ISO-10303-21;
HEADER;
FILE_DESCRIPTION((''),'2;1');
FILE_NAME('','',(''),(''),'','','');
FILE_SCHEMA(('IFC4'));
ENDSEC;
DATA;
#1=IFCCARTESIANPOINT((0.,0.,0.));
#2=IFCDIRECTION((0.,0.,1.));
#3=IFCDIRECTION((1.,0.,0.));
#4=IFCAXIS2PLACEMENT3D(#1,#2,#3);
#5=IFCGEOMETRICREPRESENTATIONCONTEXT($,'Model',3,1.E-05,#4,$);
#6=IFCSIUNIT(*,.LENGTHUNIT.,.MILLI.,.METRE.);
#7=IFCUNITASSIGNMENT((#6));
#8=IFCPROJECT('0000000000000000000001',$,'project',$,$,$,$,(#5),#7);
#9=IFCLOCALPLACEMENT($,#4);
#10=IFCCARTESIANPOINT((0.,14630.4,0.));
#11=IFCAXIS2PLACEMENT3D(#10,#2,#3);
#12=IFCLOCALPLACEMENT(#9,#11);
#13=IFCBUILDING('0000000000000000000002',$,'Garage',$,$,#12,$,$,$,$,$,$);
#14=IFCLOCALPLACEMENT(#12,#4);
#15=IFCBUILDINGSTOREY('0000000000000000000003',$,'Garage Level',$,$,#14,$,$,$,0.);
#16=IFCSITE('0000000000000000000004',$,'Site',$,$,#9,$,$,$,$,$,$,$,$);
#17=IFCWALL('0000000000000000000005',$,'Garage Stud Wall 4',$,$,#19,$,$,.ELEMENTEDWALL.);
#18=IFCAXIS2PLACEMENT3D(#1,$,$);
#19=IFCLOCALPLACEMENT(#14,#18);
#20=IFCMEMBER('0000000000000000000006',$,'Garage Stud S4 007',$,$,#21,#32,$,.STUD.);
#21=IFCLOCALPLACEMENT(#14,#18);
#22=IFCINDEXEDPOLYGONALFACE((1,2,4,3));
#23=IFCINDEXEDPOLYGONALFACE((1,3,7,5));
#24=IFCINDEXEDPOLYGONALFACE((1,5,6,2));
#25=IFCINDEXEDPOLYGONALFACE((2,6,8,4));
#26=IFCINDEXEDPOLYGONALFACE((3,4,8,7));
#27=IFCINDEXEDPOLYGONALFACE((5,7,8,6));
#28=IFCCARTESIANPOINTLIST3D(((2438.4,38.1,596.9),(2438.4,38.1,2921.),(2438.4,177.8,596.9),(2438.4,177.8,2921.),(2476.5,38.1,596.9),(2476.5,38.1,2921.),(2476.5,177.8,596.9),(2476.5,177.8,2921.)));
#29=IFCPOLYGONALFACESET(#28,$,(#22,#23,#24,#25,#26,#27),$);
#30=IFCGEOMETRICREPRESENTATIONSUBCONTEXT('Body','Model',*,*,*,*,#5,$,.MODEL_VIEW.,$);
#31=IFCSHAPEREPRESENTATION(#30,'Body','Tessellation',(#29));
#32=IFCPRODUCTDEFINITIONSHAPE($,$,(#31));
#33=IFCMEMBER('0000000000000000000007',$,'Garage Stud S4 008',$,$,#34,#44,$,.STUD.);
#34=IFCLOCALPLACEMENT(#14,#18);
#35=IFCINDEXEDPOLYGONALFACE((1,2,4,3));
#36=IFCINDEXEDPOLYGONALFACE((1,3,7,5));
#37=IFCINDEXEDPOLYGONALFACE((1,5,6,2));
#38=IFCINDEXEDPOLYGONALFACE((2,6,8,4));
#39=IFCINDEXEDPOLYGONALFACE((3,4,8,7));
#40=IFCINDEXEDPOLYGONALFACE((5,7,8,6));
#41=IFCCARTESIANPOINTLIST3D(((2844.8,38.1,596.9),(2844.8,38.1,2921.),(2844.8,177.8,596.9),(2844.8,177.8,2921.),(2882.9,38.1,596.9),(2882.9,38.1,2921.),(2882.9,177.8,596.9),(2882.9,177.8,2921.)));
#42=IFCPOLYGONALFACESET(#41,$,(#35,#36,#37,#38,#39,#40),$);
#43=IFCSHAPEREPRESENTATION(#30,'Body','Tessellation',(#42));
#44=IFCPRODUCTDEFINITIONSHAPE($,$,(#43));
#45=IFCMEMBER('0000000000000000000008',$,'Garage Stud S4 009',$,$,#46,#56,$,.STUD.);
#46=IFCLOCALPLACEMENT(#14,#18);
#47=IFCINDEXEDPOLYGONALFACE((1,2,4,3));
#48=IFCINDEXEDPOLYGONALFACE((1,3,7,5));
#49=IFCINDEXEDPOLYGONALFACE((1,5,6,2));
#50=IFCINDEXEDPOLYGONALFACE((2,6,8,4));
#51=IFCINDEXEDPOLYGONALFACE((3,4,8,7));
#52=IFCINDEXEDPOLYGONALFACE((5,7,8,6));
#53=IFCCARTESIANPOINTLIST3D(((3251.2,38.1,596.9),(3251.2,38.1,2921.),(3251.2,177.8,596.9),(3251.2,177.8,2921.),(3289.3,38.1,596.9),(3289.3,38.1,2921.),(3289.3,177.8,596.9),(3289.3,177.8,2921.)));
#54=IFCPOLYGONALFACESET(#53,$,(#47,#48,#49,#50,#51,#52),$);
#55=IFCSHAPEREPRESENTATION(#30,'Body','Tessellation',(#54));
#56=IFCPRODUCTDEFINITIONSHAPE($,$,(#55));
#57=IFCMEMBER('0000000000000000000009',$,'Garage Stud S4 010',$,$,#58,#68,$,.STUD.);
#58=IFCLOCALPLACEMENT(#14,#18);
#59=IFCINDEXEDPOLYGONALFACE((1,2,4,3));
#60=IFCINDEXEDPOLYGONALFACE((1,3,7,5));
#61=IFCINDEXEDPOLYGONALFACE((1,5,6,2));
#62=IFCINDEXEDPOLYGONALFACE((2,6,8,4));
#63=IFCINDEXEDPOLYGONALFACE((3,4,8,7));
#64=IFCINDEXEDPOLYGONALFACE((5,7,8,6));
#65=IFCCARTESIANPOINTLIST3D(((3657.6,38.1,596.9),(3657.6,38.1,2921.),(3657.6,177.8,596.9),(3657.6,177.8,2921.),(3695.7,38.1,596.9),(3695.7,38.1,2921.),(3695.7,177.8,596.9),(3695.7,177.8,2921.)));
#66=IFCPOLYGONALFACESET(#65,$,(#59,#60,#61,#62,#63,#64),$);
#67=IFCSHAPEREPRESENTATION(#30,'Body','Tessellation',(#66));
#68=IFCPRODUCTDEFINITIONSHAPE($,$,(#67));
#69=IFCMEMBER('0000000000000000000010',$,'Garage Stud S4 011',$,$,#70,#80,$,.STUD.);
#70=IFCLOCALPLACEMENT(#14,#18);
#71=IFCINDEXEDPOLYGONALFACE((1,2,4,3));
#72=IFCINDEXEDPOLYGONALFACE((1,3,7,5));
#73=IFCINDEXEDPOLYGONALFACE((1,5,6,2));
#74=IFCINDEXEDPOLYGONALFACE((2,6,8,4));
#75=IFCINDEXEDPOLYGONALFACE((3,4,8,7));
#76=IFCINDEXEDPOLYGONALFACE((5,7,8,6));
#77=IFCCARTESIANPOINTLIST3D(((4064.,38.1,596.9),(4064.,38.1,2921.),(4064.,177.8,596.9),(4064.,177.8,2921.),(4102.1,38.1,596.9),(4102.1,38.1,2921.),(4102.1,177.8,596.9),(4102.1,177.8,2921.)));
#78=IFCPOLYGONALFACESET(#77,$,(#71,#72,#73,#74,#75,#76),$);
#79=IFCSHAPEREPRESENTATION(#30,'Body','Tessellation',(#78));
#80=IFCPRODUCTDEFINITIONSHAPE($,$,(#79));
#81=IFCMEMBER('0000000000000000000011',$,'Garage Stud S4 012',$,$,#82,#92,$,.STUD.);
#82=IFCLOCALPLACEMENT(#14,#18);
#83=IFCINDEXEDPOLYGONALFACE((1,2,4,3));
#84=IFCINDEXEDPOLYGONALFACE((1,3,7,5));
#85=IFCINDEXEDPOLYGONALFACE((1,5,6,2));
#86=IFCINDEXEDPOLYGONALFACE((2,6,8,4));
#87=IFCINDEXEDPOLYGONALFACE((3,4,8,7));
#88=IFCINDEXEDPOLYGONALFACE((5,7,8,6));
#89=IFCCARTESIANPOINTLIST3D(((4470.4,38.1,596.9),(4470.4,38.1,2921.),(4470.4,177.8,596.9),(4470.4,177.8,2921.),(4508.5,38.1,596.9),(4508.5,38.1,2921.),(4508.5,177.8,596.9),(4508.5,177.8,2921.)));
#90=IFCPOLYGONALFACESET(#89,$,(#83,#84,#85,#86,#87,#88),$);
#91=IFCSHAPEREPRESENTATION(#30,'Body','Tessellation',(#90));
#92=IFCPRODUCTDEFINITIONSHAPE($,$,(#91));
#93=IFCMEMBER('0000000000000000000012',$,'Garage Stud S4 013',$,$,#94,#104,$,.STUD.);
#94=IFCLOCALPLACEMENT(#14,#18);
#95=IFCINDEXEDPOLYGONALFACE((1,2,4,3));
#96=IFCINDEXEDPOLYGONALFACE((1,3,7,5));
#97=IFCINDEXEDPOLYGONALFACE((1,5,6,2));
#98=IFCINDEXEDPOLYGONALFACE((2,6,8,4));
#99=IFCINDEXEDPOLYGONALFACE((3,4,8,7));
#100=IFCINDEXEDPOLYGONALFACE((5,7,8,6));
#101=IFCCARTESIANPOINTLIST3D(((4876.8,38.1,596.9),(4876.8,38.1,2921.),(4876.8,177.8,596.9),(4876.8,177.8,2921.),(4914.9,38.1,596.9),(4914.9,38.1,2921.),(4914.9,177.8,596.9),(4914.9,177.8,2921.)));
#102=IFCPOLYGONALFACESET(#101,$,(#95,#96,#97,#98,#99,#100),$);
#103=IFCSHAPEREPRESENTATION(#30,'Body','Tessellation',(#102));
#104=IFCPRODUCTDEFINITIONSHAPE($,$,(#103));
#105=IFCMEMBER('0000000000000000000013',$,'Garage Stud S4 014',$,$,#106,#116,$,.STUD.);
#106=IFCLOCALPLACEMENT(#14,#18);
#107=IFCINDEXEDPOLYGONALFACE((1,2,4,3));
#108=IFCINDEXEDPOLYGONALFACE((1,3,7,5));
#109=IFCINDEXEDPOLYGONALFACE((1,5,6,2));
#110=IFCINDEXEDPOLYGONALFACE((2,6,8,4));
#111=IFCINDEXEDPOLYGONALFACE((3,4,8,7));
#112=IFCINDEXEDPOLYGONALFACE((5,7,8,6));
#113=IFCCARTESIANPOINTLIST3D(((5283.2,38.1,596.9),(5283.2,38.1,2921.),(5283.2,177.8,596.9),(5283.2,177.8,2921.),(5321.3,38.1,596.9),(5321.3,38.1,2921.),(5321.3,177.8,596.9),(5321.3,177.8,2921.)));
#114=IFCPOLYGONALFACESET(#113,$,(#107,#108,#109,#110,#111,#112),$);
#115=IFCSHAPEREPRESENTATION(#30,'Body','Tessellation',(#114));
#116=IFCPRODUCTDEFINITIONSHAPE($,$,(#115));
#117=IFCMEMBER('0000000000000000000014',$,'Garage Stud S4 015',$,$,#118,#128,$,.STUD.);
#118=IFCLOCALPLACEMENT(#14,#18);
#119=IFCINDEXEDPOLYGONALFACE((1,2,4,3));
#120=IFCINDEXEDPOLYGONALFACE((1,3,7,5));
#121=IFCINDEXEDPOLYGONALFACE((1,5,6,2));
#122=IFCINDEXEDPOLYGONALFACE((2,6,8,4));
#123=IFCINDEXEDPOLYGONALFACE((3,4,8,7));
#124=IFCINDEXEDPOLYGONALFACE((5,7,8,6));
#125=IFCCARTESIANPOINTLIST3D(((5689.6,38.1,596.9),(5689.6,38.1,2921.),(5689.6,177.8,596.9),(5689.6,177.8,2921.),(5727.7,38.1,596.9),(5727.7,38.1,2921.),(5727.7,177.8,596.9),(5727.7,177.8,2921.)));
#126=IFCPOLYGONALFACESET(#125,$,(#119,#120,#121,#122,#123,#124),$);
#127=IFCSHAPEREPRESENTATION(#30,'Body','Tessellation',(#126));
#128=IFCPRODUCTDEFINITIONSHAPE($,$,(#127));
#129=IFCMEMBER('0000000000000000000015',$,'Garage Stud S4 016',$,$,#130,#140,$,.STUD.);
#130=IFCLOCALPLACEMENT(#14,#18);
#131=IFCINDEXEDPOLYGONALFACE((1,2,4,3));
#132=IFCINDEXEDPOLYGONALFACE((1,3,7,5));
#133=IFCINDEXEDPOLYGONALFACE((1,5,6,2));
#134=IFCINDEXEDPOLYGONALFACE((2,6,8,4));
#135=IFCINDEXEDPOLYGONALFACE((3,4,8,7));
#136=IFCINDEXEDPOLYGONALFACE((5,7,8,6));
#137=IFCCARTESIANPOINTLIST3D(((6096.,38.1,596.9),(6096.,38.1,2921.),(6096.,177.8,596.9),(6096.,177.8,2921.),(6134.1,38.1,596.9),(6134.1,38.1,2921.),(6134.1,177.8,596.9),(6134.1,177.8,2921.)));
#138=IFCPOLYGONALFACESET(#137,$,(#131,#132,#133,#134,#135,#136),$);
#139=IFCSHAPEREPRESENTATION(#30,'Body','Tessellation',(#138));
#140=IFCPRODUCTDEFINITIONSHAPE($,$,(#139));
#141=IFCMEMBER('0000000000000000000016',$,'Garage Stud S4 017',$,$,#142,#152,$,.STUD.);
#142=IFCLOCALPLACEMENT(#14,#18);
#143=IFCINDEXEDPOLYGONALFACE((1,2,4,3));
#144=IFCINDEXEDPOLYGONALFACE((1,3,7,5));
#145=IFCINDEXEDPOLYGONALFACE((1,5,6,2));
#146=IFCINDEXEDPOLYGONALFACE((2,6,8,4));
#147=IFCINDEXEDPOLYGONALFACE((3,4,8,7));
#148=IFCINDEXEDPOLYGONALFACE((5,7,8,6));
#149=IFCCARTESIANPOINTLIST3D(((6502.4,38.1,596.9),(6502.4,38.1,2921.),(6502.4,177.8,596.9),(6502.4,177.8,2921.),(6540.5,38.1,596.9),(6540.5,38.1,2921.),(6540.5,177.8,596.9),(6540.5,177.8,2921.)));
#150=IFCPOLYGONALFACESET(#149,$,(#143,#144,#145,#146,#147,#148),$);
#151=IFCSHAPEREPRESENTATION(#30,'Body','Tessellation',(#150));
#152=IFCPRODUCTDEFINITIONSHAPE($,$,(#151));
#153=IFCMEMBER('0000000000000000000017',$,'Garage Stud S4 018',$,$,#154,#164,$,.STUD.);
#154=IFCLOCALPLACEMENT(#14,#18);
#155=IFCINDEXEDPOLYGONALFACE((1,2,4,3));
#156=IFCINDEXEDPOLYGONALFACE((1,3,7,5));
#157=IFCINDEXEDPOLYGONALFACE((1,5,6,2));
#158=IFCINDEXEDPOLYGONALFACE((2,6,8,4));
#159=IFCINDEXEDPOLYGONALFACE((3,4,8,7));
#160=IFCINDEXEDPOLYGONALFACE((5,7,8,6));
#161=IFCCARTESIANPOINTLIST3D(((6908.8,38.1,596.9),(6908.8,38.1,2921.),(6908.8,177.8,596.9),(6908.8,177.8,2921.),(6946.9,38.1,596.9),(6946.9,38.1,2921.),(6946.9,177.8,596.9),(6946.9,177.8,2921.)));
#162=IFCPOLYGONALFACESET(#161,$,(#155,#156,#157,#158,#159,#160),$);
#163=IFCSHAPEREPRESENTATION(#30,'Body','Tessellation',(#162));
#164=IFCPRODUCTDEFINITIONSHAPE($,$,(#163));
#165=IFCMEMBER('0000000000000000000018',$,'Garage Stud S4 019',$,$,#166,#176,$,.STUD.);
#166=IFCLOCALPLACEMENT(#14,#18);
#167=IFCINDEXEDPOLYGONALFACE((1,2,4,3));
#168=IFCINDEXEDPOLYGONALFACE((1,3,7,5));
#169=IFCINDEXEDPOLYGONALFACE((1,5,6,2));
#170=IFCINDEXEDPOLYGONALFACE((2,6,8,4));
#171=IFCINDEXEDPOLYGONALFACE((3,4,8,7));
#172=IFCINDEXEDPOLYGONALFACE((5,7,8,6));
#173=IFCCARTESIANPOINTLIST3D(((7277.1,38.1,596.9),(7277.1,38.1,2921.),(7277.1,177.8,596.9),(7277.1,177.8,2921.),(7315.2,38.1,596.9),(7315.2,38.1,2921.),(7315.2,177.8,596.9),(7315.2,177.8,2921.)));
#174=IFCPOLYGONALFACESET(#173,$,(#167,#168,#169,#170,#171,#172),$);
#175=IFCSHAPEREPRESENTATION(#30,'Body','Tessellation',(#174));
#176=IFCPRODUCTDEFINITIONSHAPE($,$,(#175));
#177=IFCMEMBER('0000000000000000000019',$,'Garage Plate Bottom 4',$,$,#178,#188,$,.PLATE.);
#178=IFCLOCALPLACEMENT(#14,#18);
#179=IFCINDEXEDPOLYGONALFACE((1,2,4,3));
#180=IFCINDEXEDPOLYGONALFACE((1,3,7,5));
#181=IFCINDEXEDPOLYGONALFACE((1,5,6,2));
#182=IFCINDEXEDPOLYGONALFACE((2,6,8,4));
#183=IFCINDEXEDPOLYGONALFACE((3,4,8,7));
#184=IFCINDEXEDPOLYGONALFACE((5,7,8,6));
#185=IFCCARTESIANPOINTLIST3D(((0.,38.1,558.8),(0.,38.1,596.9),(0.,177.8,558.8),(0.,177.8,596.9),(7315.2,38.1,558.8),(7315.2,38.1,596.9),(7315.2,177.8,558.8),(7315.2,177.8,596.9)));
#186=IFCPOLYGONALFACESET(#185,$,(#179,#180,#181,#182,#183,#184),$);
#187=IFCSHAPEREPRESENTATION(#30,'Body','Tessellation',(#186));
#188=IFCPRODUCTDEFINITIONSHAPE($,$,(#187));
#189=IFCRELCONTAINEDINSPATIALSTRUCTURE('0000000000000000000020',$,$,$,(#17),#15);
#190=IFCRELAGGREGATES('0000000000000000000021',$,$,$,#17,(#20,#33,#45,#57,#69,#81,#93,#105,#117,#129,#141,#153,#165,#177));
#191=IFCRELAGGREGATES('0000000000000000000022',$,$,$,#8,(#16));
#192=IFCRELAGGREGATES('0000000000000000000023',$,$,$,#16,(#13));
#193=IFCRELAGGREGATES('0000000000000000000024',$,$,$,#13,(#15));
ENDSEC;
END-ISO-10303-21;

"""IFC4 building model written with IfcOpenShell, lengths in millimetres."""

from ifc_helpers import new_model, si_unit, frame, origin_with_axes, origin_2d, place, context, subcontext, project, spatial, rectangle, extrude, element, aggregate, save


model = new_model("IFC4")

# Units and contexts
model_context = context("Model", 3, precision=1e-05, world=origin_with_axes())
body_context = subcontext(model_context, "Body", "Model", "MODEL_VIEW")
ifc_project = project(units=[si_unit("LENGTHUNIT", "METRE", prefix="MILLI")], contexts=[model_context])

# Site, building, storey
site_placement = place(None, origin_with_axes())
site = spatial("IfcSite", under=ifc_project, at=site_placement, Name="Site")
building_placement = place(site_placement, frame((0.0, 14630.4, 0.0), z_axis=(0.0, 0.0, 1.0), x_axis=(1.0, 0.0, 0.0)))
building = spatial("IfcBuilding", under=site, at=building_placement, Name="Garage")
storey_placement = place(building_placement, origin_with_axes())
storey = spatial("IfcBuildingStorey", under=building, at=storey_placement, Name="Garage Level", Elevation=0.0)

# Wall, members
wall_1_placement = place(storey_placement, frame((0.0, 0.0, 558.8), z_axis=(0.0, 0.0, 1.0), x_axis=(1.0, 0.0, 0.0)))
wall_1 = element("IfcWall", 1, at=wall_1_placement, inside=storey, Name="Garage Stud Wall 4", PredefinedType="ELEMENTEDWALL")
member_1_placement = place(wall_1_placement, frame((2457.4, 108.0, 38.1), z_axis=(0.0, 0.0, 1.0), x_axis=(1.0, 0.0, 0.0)))
member_1 = element("IfcMember", 2, at=member_1_placement, Name="Garage Stud S4 007", PredefinedType="STUD", context=body_context, shape_type="SweptSolid", body=[
    extrude(rectangle(XDim=38.1, YDim=139.7, at=origin_2d()), origin_with_axes(), (0.0, 0.0, 1.0), 2324.1),
])
member_2_placement = place(wall_1_placement, frame((2863.8, 108.0, 38.1), z_axis=(0.0, 0.0, 1.0), x_axis=(1.0, 0.0, 0.0)))
member_2 = element("IfcMember", 3, at=member_2_placement, Name="Garage Stud S4 008", PredefinedType="STUD", context=body_context, shape_type="SweptSolid", body=[
    extrude(rectangle(XDim=38.1, YDim=139.7, at=origin_2d()), origin_with_axes(), (0.0, 0.0, 1.0), 2324.1),
])
member_3_placement = place(wall_1_placement, frame((3270.2, 108.0, 38.1), z_axis=(0.0, 0.0, 1.0), x_axis=(1.0, 0.0, 0.0)))
member_3 = element("IfcMember", 4, at=member_3_placement, Name="Garage Stud S4 009", PredefinedType="STUD", context=body_context, shape_type="SweptSolid", body=[
    extrude(rectangle(XDim=38.1, YDim=139.7, at=origin_2d()), origin_with_axes(), (0.0, 0.0, 1.0), 2324.1),
])
member_4_placement = place(wall_1_placement, frame((3676.7, 108.0, 38.1), z_axis=(0.0, 0.0, 1.0), x_axis=(1.0, 0.0, 0.0)))
member_4 = element("IfcMember", 5, at=member_4_placement, Name="Garage Stud S4 010", PredefinedType="STUD", context=body_context, shape_type="SweptSolid", body=[
    extrude(rectangle(XDim=38.1, YDim=139.7, at=origin_2d()), origin_with_axes(), (0.0, 0.0, 1.0), 2324.1),
])
member_5_placement = place(wall_1_placement, frame((4083.1, 108.0, 38.1), z_axis=(0.0, 0.0, 1.0), x_axis=(1.0, 0.0, 0.0)))
member_5 = element("IfcMember", 6, at=member_5_placement, Name="Garage Stud S4 011", PredefinedType="STUD", context=body_context, shape_type="SweptSolid", body=[
    extrude(rectangle(XDim=38.1, YDim=139.7, at=origin_2d()), origin_with_axes(), (0.0, 0.0, 1.0), 2324.1),
])
member_6_placement = place(wall_1_placement, frame((4489.4, 108.0, 38.1), z_axis=(0.0, 0.0, 1.0), x_axis=(1.0, 0.0, 0.0)))
member_6 = element("IfcMember", 7, at=member_6_placement, Name="Garage Stud S4 012", PredefinedType="STUD", context=body_context, shape_type="SweptSolid", body=[
    extrude(rectangle(XDim=38.1, YDim=139.7, at=origin_2d()), origin_with_axes(), (0.0, 0.0, 1.0), 2324.1),
])
member_7_placement = place(wall_1_placement, frame((4895.9, 108.0, 38.1), z_axis=(0.0, 0.0, 1.0), x_axis=(1.0, 0.0, 0.0)))
member_7 = element("IfcMember", 8, at=member_7_placement, Name="Garage Stud S4 013", PredefinedType="STUD", context=body_context, shape_type="SweptSolid", body=[
    extrude(rectangle(XDim=38.1, YDim=139.7, at=origin_2d()), origin_with_axes(), (0.0, 0.0, 1.0), 2324.1),
])
member_8_placement = place(wall_1_placement, frame((5302.2, 108.0, 38.1), z_axis=(0.0, 0.0, 1.0), x_axis=(1.0, 0.0, 0.0)))
member_8 = element("IfcMember", 9, at=member_8_placement, Name="Garage Stud S4 014", PredefinedType="STUD", context=body_context, shape_type="SweptSolid", body=[
    extrude(rectangle(XDim=38.1, YDim=139.7, at=origin_2d()), origin_with_axes(), (0.0, 0.0, 1.0), 2324.1),
])
member_9_placement = place(wall_1_placement, frame((5708.6, 108.0, 38.1), z_axis=(0.0, 0.0, 1.0), x_axis=(1.0, 0.0, 0.0)))
member_9 = element("IfcMember", 10, at=member_9_placement, Name="Garage Stud S4 015", PredefinedType="STUD", context=body_context, shape_type="SweptSolid", body=[
    extrude(rectangle(XDim=38.1, YDim=139.7, at=origin_2d()), origin_with_axes(), (0.0, 0.0, 1.0), 2324.1),
])
member_10_placement = place(wall_1_placement, frame((6115.1, 108.0, 38.1), z_axis=(0.0, 0.0, 1.0), x_axis=(1.0, 0.0, 0.0)))
member_10 = element("IfcMember", 11, at=member_10_placement, Name="Garage Stud S4 016", PredefinedType="STUD", context=body_context, shape_type="SweptSolid", body=[
    extrude(rectangle(XDim=38.1, YDim=139.7, at=origin_2d()), origin_with_axes(), (0.0, 0.0, 1.0), 2324.1),
])
member_11_placement = place(wall_1_placement, frame((6521.4, 108.0, 38.1), z_axis=(0.0, 0.0, 1.0), x_axis=(1.0, 0.0, 0.0)))
member_11 = element("IfcMember", 12, at=member_11_placement, Name="Garage Stud S4 017", PredefinedType="STUD", context=body_context, shape_type="SweptSolid", body=[
    extrude(rectangle(XDim=38.1, YDim=139.7, at=origin_2d()), origin_with_axes(), (0.0, 0.0, 1.0), 2324.1),
])
member_12_placement = place(wall_1_placement, frame((6927.9, 108.0, 38.1), z_axis=(0.0, 0.0, 1.0), x_axis=(1.0, 0.0, 0.0)))
member_12 = element("IfcMember", 13, at=member_12_placement, Name="Garage Stud S4 018", PredefinedType="STUD", context=body_context, shape_type="SweptSolid", body=[
    extrude(rectangle(XDim=38.1, YDim=139.7, at=origin_2d()), origin_with_axes(), (0.0, 0.0, 1.0), 2324.1),
])
member_13_placement = place(wall_1_placement, frame((7296.1, 108.0, 38.1), z_axis=(0.0, 0.0, 1.0), x_axis=(1.0, 0.0, 0.0)))
member_13 = element("IfcMember", 14, at=member_13_placement, Name="Garage Stud S4 019", PredefinedType="STUD", context=body_context, shape_type="SweptSolid", body=[
    extrude(rectangle(XDim=38.1, YDim=139.7, at=origin_2d()), origin_with_axes(), (0.0, 0.0, 1.0), 2324.1),
])
member_14_placement = place(wall_1_placement, frame((0.0, 108.0, 19.1), z_axis=(1.0, 0.0, 0.0), x_axis=(0.0, 0.0, 1.0)))
member_14 = element("IfcMember", 15, at=member_14_placement, Name="Garage Plate Bottom 4", PredefinedType="PLATE", context=body_context, shape_type="SweptSolid", body=[
    extrude(rectangle(XDim=38.1, YDim=139.7, at=origin_2d()), origin_with_axes(), (0.0, 0.0, 1.0), 7315.2),
])
aggregate(wall_1, [member_1, member_2, member_3, member_4, member_5, member_6, member_7, member_8, member_9, member_10, member_11, member_12, member_13, member_14])

save(model, "model.ifc")
